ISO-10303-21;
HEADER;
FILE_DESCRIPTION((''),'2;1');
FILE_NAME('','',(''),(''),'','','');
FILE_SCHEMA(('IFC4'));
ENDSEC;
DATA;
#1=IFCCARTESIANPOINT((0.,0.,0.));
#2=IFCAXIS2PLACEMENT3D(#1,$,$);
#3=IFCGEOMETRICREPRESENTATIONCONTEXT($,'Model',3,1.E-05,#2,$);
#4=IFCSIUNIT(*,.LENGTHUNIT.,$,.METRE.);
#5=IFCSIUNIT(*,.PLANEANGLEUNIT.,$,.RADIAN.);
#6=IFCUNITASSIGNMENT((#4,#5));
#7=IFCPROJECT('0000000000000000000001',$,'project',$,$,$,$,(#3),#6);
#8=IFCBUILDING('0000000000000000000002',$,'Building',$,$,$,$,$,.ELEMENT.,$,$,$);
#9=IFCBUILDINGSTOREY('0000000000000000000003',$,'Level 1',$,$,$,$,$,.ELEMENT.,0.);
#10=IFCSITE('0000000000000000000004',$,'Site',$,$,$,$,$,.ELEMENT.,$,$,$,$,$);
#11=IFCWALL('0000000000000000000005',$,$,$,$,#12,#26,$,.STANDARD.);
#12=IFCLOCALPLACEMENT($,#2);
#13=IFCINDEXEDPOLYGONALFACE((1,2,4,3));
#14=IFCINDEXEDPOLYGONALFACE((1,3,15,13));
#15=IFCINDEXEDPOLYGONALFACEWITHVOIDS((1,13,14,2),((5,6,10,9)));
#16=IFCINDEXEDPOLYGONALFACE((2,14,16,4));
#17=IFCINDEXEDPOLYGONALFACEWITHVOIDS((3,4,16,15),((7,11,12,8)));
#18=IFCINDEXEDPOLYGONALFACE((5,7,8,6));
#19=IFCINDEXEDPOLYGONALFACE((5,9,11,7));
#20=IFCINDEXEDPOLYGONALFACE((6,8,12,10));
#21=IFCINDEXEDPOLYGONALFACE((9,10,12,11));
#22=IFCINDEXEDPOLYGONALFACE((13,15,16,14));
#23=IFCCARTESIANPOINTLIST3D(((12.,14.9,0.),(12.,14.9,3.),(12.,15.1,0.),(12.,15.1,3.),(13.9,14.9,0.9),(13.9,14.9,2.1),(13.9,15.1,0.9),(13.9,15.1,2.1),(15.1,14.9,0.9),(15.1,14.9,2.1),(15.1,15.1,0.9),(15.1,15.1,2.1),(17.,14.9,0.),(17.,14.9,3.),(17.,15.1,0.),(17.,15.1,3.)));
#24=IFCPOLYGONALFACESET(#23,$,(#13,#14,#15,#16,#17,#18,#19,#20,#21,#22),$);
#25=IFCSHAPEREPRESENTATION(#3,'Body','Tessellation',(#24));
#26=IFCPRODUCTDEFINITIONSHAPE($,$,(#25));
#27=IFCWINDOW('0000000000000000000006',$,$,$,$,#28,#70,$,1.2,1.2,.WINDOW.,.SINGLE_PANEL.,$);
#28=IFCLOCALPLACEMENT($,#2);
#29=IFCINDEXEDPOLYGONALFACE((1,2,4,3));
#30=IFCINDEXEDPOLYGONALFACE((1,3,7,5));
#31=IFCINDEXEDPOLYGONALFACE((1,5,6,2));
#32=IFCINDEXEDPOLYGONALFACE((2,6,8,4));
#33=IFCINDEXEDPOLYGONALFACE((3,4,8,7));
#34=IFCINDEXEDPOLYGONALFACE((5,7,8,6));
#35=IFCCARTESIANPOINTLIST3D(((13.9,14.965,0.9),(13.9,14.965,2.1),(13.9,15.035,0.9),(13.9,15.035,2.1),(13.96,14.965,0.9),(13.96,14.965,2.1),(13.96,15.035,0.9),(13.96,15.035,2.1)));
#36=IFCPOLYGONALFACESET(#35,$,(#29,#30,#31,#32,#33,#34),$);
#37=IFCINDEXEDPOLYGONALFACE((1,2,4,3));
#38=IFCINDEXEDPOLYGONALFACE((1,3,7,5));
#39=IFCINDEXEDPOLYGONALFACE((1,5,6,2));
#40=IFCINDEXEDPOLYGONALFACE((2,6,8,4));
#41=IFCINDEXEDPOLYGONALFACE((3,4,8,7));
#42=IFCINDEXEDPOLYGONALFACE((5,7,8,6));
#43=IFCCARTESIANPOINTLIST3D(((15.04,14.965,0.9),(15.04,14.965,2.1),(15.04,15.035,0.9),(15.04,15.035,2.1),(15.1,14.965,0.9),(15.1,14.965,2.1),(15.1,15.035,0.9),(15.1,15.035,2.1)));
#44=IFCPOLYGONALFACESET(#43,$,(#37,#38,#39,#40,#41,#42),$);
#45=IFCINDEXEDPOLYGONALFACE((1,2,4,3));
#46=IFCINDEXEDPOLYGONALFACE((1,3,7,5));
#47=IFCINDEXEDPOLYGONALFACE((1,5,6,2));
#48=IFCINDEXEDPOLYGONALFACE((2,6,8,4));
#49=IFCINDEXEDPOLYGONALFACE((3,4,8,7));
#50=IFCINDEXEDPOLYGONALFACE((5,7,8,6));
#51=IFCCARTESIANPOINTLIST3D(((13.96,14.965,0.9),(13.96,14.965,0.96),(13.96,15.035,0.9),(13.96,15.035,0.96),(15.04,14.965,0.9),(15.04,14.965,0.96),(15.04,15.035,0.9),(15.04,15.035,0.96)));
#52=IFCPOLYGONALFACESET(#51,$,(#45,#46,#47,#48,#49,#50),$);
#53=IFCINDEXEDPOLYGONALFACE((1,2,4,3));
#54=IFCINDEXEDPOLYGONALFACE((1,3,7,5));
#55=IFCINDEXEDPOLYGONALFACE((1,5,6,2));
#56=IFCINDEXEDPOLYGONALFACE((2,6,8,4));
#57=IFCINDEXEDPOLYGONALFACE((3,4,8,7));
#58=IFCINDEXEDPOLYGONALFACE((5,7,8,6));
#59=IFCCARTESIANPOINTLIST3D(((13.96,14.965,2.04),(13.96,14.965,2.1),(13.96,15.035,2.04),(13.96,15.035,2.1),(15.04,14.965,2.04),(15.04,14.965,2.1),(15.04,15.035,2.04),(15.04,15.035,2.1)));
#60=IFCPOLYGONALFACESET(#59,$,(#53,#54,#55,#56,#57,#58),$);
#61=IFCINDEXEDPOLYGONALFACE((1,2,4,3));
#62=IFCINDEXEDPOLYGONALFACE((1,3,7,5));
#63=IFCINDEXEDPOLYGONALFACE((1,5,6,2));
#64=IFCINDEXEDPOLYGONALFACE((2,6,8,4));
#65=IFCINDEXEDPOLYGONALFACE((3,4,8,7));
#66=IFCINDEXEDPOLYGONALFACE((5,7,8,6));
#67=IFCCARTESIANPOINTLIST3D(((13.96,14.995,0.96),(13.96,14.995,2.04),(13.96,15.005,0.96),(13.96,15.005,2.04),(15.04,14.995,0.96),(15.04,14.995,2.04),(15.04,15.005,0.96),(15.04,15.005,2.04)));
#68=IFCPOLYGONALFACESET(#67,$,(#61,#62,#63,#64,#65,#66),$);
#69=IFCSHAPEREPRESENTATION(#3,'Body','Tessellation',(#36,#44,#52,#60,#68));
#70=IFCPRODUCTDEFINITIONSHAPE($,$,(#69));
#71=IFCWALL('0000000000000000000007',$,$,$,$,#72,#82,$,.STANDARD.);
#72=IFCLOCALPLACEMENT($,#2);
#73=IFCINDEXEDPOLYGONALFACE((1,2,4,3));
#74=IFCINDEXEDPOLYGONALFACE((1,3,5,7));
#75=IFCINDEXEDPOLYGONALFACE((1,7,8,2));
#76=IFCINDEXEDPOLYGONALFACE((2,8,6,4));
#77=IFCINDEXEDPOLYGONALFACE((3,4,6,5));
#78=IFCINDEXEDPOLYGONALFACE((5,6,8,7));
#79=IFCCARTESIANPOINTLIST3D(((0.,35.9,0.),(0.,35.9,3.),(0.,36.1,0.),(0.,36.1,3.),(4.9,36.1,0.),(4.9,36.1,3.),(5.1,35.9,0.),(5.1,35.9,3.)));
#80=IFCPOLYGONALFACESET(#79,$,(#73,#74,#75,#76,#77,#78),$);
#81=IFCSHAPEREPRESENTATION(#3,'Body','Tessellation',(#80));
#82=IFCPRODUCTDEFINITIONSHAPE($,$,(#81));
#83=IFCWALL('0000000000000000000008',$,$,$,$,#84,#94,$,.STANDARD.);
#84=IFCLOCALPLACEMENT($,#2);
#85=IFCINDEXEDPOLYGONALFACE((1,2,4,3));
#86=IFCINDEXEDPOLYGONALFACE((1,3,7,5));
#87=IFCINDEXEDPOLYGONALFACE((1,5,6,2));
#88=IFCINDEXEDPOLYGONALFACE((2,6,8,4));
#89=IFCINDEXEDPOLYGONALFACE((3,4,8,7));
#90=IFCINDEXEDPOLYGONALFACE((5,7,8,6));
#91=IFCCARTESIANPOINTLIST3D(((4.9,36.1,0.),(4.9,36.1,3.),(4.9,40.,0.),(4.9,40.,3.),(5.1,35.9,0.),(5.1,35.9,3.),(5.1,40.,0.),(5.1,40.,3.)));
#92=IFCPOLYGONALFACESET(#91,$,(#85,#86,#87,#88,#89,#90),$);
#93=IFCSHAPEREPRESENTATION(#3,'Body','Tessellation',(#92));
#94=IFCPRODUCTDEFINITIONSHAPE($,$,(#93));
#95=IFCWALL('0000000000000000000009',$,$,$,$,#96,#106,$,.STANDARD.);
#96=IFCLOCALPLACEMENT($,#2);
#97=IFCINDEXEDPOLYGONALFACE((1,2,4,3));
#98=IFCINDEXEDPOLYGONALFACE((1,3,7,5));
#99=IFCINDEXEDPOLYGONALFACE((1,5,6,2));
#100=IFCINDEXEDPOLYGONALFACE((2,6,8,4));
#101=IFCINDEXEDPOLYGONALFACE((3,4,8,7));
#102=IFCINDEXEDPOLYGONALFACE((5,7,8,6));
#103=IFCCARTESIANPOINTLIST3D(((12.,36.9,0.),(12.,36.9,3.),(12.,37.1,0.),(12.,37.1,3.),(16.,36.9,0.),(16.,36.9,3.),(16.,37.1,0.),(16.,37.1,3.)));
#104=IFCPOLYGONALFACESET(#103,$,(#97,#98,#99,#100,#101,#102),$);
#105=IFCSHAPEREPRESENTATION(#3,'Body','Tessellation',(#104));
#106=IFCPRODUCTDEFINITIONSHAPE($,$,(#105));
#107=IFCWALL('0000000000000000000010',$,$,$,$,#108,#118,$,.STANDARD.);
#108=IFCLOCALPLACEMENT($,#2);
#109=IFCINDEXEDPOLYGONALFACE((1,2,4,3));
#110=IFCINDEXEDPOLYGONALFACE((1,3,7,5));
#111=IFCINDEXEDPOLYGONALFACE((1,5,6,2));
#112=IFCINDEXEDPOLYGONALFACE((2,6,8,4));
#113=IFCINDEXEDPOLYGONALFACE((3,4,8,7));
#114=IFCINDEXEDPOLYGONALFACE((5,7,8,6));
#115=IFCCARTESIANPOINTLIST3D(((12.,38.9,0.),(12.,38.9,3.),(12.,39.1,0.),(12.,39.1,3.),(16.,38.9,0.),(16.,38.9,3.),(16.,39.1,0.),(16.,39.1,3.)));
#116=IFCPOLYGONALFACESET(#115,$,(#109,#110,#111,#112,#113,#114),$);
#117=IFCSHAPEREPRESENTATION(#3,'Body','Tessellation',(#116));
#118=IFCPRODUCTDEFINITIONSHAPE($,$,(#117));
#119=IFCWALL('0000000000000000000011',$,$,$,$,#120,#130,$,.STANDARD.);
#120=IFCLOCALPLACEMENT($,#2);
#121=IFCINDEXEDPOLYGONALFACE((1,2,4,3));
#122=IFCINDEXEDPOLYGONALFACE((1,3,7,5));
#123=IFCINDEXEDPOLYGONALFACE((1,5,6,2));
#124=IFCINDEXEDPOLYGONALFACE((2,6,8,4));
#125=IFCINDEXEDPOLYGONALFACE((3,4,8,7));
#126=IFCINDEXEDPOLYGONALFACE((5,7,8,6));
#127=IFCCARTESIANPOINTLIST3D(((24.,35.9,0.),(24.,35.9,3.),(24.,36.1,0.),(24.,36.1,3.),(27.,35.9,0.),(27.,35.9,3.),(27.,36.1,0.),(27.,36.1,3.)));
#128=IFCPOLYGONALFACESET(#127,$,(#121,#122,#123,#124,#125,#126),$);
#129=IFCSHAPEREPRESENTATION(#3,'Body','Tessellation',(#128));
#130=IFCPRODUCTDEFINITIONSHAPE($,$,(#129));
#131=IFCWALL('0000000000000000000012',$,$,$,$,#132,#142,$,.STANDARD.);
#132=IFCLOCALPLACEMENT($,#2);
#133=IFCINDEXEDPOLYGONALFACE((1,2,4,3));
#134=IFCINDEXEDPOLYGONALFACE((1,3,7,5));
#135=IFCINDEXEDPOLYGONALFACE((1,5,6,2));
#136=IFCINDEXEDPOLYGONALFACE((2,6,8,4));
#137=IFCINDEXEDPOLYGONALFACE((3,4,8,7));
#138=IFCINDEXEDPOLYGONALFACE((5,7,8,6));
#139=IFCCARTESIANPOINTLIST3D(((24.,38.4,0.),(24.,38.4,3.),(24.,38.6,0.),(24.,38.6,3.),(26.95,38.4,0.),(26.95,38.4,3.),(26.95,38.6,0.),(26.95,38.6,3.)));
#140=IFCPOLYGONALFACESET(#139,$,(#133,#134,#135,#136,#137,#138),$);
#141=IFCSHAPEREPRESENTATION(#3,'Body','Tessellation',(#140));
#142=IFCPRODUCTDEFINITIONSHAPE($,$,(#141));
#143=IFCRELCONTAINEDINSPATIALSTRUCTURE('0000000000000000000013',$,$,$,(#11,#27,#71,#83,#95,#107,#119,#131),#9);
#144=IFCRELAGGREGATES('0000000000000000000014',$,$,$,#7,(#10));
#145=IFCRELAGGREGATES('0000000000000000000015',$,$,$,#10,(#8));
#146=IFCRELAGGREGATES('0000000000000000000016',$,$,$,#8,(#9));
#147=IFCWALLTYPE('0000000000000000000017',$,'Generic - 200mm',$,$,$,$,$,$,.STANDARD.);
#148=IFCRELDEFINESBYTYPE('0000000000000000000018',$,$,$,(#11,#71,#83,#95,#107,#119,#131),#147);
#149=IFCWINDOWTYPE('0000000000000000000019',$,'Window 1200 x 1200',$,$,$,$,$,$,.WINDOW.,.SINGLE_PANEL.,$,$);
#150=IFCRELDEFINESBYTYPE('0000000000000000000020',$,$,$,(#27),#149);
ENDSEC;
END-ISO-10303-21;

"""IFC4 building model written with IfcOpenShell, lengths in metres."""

from ifc_helpers import new_model, si_unit, frame, frame_2d, origin, origin_with_axes, origin_2d, place, context, project, spatial, polyline, rectangle, outline, extrude, type_object, element, fill, save


model = new_model("IFC4")

# Units and contexts
model_context = context("Model", 3, precision=1e-05, world=origin())
ifc_project = project(units=[si_unit("LENGTHUNIT", "METRE"), si_unit("PLANEANGLEUNIT", "RADIAN")], contexts=[model_context])

# Site, building, storey
site = spatial("IfcSite", under=ifc_project, Name="Site", CompositionType="ELEMENT")
building = spatial("IfcBuilding", under=site, Name="Building", CompositionType="ELEMENT")
storey = spatial("IfcBuildingStorey", under=building, Name="Level 1", CompositionType="ELEMENT", Elevation=0.0)

# Shared definitions
wall_type = type_object("IfcWallType", Name="Generic - 200mm", PredefinedType="STANDARD")

# Wall, opening, window
window_type = type_object("IfcWindowType", Name="Window 1200 x 1200", PartitioningType="SINGLE_PANEL", PredefinedType="WINDOW")
wall_1_placement = place(None, frame((12.0, 15.0, 0.0), z_axis=(0.0, 0.0, 1.0), x_axis=(1.0, 0.0, 0.0)))
wall_1 = element("IfcWall", 1, at=wall_1_placement, inside=storey, type_object=wall_type, PredefinedType="STANDARD", context=model_context, shape_type="SweptSolid", body=[
    extrude(rectangle(XDim=5.0, YDim=0.2, at=frame_2d((2.5, 0.0))), origin(), (0.0, 0.0, 1.0), 3.0),
])
opening_1_placement = place(wall_1_placement, frame((2.5, 0.0, 0.9), z_axis=(0.0, 0.0, 1.0), x_axis=(1.0, 0.0, 0.0)))
opening_1 = element("IfcOpeningElement", 2, at=opening_1_placement, cuts=wall_1, PredefinedType="OPENING", context=model_context, shape_type="SweptSolid", body=[
    extrude(rectangle(XDim=1.2, YDim=0.202, at=origin_2d()), origin(), (0.0, 0.0, 1.0), 1.2),
])
window_1_placement = place(opening_1_placement, origin_with_axes())
window_1 = element("IfcWindow", 3, at=window_1_placement, inside=storey, type_object=window_type, OverallHeight=1.2, OverallWidth=1.2, PartitioningType="SINGLE_PANEL", PredefinedType="WINDOW", context=model_context, shape_type="SweptSolid", body=[
    extrude(rectangle(XDim=0.06, YDim=0.07, at=frame_2d((-0.57, 0.0))), origin(), (0.0, 0.0, 1.0), 1.2),
    extrude(rectangle(XDim=0.06, YDim=0.07, at=frame_2d((0.57, 0.0))), origin(), (0.0, 0.0, 1.0), 1.2),
    extrude(rectangle(XDim=1.08, YDim=0.07, at=origin_2d()), origin(), (0.0, 0.0, 1.0), 0.06),
    extrude(rectangle(XDim=1.08, YDim=0.07, at=origin_2d()), frame((0.0, 0.0, 1.14)), (0.0, 0.0, 1.0), 0.06),
    extrude(rectangle(XDim=1.08, YDim=0.01, at=origin_2d()), frame((0.0, 0.0, 0.06)), (0.0, 0.0, 1.0), 1.08),
])
fill(opening_1, window_1)

# Walls
wall_2_placement = place(None, frame((0.0, 36.0, 0.0), z_axis=(0.0, 0.0, 1.0), x_axis=(1.0, 0.0, 0.0)))
element("IfcWall", 4, at=wall_2_placement, inside=storey, type_object=wall_type, PredefinedType="STANDARD", context=model_context, shape_type="SweptSolid", body=[
    extrude(outline(polyline([(0.0, -0.1), (5.1, -0.1), (4.9, 0.1), (0.0, 0.1), (0.0, -0.1)])), origin(), (0.0, 0.0, 1.0), 3.0),
])
wall_3_placement = place(None, frame((5.0, 36.0, 0.0), z_axis=(0.0, 0.0, 1.0), x_axis=(0.0, 1.0, 0.0)))
element("IfcWall", 5, at=wall_3_placement, inside=storey, type_object=wall_type, PredefinedType="STANDARD", context=model_context, shape_type="SweptSolid", body=[
    extrude(outline(polyline([(-0.1, -0.1), (4.0, -0.1), (4.0, 0.1), (0.1, 0.1), (-0.1, -0.1)])), origin(), (0.0, 0.0, 1.0), 3.0),
])
for number, where, z_axis, x_axis in (
    (6, (12.0, 37.0, 0.0), (0.0, 0.0, 1.0), (1.0, 0.0, 0.0)),
    (7, (12.0, 39.0, 0.0), (0.0, 0.0, 1.0), (1.0, 0.0, 0.0)),
):
    element("IfcWall", number, at=place(None, frame(where, z_axis=z_axis, x_axis=x_axis)), inside=storey, type_object=wall_type, PredefinedType="STANDARD", context=model_context, shape_type="SweptSolid", body=[
        extrude(rectangle(XDim=4.0, YDim=0.2, at=frame_2d((2.0, 0.0))), origin(), (0.0, 0.0, 1.0), 3.0),
    ])
wall_4_placement = place(None, frame((24.0, 36.0, 0.0), z_axis=(0.0, 0.0, 1.0), x_axis=(1.0, 0.0, 0.0)))
element("IfcWall", 8, at=wall_4_placement, inside=storey, type_object=wall_type, PredefinedType="STANDARD", context=model_context, shape_type="SweptSolid", body=[
    extrude(rectangle(XDim=3.0, YDim=0.2, at=frame_2d((1.5, 0.0))), origin(), (0.0, 0.0, 1.0), 3.0),
])
wall_5_placement = place(None, frame((24.0, 38.5, 0.0), z_axis=(0.0, 0.0, 1.0), x_axis=(1.0, 0.0, 0.0)))
element("IfcWall", 9, at=wall_5_placement, inside=storey, type_object=wall_type, PredefinedType="STANDARD", context=model_context, shape_type="SweptSolid", body=[
    extrude(rectangle(XDim=2.95, YDim=0.2, at=frame_2d((1.475, 0.0))), origin(), (0.0, 0.0, 1.0), 3.0),
])

save(model, "model.ifc")
